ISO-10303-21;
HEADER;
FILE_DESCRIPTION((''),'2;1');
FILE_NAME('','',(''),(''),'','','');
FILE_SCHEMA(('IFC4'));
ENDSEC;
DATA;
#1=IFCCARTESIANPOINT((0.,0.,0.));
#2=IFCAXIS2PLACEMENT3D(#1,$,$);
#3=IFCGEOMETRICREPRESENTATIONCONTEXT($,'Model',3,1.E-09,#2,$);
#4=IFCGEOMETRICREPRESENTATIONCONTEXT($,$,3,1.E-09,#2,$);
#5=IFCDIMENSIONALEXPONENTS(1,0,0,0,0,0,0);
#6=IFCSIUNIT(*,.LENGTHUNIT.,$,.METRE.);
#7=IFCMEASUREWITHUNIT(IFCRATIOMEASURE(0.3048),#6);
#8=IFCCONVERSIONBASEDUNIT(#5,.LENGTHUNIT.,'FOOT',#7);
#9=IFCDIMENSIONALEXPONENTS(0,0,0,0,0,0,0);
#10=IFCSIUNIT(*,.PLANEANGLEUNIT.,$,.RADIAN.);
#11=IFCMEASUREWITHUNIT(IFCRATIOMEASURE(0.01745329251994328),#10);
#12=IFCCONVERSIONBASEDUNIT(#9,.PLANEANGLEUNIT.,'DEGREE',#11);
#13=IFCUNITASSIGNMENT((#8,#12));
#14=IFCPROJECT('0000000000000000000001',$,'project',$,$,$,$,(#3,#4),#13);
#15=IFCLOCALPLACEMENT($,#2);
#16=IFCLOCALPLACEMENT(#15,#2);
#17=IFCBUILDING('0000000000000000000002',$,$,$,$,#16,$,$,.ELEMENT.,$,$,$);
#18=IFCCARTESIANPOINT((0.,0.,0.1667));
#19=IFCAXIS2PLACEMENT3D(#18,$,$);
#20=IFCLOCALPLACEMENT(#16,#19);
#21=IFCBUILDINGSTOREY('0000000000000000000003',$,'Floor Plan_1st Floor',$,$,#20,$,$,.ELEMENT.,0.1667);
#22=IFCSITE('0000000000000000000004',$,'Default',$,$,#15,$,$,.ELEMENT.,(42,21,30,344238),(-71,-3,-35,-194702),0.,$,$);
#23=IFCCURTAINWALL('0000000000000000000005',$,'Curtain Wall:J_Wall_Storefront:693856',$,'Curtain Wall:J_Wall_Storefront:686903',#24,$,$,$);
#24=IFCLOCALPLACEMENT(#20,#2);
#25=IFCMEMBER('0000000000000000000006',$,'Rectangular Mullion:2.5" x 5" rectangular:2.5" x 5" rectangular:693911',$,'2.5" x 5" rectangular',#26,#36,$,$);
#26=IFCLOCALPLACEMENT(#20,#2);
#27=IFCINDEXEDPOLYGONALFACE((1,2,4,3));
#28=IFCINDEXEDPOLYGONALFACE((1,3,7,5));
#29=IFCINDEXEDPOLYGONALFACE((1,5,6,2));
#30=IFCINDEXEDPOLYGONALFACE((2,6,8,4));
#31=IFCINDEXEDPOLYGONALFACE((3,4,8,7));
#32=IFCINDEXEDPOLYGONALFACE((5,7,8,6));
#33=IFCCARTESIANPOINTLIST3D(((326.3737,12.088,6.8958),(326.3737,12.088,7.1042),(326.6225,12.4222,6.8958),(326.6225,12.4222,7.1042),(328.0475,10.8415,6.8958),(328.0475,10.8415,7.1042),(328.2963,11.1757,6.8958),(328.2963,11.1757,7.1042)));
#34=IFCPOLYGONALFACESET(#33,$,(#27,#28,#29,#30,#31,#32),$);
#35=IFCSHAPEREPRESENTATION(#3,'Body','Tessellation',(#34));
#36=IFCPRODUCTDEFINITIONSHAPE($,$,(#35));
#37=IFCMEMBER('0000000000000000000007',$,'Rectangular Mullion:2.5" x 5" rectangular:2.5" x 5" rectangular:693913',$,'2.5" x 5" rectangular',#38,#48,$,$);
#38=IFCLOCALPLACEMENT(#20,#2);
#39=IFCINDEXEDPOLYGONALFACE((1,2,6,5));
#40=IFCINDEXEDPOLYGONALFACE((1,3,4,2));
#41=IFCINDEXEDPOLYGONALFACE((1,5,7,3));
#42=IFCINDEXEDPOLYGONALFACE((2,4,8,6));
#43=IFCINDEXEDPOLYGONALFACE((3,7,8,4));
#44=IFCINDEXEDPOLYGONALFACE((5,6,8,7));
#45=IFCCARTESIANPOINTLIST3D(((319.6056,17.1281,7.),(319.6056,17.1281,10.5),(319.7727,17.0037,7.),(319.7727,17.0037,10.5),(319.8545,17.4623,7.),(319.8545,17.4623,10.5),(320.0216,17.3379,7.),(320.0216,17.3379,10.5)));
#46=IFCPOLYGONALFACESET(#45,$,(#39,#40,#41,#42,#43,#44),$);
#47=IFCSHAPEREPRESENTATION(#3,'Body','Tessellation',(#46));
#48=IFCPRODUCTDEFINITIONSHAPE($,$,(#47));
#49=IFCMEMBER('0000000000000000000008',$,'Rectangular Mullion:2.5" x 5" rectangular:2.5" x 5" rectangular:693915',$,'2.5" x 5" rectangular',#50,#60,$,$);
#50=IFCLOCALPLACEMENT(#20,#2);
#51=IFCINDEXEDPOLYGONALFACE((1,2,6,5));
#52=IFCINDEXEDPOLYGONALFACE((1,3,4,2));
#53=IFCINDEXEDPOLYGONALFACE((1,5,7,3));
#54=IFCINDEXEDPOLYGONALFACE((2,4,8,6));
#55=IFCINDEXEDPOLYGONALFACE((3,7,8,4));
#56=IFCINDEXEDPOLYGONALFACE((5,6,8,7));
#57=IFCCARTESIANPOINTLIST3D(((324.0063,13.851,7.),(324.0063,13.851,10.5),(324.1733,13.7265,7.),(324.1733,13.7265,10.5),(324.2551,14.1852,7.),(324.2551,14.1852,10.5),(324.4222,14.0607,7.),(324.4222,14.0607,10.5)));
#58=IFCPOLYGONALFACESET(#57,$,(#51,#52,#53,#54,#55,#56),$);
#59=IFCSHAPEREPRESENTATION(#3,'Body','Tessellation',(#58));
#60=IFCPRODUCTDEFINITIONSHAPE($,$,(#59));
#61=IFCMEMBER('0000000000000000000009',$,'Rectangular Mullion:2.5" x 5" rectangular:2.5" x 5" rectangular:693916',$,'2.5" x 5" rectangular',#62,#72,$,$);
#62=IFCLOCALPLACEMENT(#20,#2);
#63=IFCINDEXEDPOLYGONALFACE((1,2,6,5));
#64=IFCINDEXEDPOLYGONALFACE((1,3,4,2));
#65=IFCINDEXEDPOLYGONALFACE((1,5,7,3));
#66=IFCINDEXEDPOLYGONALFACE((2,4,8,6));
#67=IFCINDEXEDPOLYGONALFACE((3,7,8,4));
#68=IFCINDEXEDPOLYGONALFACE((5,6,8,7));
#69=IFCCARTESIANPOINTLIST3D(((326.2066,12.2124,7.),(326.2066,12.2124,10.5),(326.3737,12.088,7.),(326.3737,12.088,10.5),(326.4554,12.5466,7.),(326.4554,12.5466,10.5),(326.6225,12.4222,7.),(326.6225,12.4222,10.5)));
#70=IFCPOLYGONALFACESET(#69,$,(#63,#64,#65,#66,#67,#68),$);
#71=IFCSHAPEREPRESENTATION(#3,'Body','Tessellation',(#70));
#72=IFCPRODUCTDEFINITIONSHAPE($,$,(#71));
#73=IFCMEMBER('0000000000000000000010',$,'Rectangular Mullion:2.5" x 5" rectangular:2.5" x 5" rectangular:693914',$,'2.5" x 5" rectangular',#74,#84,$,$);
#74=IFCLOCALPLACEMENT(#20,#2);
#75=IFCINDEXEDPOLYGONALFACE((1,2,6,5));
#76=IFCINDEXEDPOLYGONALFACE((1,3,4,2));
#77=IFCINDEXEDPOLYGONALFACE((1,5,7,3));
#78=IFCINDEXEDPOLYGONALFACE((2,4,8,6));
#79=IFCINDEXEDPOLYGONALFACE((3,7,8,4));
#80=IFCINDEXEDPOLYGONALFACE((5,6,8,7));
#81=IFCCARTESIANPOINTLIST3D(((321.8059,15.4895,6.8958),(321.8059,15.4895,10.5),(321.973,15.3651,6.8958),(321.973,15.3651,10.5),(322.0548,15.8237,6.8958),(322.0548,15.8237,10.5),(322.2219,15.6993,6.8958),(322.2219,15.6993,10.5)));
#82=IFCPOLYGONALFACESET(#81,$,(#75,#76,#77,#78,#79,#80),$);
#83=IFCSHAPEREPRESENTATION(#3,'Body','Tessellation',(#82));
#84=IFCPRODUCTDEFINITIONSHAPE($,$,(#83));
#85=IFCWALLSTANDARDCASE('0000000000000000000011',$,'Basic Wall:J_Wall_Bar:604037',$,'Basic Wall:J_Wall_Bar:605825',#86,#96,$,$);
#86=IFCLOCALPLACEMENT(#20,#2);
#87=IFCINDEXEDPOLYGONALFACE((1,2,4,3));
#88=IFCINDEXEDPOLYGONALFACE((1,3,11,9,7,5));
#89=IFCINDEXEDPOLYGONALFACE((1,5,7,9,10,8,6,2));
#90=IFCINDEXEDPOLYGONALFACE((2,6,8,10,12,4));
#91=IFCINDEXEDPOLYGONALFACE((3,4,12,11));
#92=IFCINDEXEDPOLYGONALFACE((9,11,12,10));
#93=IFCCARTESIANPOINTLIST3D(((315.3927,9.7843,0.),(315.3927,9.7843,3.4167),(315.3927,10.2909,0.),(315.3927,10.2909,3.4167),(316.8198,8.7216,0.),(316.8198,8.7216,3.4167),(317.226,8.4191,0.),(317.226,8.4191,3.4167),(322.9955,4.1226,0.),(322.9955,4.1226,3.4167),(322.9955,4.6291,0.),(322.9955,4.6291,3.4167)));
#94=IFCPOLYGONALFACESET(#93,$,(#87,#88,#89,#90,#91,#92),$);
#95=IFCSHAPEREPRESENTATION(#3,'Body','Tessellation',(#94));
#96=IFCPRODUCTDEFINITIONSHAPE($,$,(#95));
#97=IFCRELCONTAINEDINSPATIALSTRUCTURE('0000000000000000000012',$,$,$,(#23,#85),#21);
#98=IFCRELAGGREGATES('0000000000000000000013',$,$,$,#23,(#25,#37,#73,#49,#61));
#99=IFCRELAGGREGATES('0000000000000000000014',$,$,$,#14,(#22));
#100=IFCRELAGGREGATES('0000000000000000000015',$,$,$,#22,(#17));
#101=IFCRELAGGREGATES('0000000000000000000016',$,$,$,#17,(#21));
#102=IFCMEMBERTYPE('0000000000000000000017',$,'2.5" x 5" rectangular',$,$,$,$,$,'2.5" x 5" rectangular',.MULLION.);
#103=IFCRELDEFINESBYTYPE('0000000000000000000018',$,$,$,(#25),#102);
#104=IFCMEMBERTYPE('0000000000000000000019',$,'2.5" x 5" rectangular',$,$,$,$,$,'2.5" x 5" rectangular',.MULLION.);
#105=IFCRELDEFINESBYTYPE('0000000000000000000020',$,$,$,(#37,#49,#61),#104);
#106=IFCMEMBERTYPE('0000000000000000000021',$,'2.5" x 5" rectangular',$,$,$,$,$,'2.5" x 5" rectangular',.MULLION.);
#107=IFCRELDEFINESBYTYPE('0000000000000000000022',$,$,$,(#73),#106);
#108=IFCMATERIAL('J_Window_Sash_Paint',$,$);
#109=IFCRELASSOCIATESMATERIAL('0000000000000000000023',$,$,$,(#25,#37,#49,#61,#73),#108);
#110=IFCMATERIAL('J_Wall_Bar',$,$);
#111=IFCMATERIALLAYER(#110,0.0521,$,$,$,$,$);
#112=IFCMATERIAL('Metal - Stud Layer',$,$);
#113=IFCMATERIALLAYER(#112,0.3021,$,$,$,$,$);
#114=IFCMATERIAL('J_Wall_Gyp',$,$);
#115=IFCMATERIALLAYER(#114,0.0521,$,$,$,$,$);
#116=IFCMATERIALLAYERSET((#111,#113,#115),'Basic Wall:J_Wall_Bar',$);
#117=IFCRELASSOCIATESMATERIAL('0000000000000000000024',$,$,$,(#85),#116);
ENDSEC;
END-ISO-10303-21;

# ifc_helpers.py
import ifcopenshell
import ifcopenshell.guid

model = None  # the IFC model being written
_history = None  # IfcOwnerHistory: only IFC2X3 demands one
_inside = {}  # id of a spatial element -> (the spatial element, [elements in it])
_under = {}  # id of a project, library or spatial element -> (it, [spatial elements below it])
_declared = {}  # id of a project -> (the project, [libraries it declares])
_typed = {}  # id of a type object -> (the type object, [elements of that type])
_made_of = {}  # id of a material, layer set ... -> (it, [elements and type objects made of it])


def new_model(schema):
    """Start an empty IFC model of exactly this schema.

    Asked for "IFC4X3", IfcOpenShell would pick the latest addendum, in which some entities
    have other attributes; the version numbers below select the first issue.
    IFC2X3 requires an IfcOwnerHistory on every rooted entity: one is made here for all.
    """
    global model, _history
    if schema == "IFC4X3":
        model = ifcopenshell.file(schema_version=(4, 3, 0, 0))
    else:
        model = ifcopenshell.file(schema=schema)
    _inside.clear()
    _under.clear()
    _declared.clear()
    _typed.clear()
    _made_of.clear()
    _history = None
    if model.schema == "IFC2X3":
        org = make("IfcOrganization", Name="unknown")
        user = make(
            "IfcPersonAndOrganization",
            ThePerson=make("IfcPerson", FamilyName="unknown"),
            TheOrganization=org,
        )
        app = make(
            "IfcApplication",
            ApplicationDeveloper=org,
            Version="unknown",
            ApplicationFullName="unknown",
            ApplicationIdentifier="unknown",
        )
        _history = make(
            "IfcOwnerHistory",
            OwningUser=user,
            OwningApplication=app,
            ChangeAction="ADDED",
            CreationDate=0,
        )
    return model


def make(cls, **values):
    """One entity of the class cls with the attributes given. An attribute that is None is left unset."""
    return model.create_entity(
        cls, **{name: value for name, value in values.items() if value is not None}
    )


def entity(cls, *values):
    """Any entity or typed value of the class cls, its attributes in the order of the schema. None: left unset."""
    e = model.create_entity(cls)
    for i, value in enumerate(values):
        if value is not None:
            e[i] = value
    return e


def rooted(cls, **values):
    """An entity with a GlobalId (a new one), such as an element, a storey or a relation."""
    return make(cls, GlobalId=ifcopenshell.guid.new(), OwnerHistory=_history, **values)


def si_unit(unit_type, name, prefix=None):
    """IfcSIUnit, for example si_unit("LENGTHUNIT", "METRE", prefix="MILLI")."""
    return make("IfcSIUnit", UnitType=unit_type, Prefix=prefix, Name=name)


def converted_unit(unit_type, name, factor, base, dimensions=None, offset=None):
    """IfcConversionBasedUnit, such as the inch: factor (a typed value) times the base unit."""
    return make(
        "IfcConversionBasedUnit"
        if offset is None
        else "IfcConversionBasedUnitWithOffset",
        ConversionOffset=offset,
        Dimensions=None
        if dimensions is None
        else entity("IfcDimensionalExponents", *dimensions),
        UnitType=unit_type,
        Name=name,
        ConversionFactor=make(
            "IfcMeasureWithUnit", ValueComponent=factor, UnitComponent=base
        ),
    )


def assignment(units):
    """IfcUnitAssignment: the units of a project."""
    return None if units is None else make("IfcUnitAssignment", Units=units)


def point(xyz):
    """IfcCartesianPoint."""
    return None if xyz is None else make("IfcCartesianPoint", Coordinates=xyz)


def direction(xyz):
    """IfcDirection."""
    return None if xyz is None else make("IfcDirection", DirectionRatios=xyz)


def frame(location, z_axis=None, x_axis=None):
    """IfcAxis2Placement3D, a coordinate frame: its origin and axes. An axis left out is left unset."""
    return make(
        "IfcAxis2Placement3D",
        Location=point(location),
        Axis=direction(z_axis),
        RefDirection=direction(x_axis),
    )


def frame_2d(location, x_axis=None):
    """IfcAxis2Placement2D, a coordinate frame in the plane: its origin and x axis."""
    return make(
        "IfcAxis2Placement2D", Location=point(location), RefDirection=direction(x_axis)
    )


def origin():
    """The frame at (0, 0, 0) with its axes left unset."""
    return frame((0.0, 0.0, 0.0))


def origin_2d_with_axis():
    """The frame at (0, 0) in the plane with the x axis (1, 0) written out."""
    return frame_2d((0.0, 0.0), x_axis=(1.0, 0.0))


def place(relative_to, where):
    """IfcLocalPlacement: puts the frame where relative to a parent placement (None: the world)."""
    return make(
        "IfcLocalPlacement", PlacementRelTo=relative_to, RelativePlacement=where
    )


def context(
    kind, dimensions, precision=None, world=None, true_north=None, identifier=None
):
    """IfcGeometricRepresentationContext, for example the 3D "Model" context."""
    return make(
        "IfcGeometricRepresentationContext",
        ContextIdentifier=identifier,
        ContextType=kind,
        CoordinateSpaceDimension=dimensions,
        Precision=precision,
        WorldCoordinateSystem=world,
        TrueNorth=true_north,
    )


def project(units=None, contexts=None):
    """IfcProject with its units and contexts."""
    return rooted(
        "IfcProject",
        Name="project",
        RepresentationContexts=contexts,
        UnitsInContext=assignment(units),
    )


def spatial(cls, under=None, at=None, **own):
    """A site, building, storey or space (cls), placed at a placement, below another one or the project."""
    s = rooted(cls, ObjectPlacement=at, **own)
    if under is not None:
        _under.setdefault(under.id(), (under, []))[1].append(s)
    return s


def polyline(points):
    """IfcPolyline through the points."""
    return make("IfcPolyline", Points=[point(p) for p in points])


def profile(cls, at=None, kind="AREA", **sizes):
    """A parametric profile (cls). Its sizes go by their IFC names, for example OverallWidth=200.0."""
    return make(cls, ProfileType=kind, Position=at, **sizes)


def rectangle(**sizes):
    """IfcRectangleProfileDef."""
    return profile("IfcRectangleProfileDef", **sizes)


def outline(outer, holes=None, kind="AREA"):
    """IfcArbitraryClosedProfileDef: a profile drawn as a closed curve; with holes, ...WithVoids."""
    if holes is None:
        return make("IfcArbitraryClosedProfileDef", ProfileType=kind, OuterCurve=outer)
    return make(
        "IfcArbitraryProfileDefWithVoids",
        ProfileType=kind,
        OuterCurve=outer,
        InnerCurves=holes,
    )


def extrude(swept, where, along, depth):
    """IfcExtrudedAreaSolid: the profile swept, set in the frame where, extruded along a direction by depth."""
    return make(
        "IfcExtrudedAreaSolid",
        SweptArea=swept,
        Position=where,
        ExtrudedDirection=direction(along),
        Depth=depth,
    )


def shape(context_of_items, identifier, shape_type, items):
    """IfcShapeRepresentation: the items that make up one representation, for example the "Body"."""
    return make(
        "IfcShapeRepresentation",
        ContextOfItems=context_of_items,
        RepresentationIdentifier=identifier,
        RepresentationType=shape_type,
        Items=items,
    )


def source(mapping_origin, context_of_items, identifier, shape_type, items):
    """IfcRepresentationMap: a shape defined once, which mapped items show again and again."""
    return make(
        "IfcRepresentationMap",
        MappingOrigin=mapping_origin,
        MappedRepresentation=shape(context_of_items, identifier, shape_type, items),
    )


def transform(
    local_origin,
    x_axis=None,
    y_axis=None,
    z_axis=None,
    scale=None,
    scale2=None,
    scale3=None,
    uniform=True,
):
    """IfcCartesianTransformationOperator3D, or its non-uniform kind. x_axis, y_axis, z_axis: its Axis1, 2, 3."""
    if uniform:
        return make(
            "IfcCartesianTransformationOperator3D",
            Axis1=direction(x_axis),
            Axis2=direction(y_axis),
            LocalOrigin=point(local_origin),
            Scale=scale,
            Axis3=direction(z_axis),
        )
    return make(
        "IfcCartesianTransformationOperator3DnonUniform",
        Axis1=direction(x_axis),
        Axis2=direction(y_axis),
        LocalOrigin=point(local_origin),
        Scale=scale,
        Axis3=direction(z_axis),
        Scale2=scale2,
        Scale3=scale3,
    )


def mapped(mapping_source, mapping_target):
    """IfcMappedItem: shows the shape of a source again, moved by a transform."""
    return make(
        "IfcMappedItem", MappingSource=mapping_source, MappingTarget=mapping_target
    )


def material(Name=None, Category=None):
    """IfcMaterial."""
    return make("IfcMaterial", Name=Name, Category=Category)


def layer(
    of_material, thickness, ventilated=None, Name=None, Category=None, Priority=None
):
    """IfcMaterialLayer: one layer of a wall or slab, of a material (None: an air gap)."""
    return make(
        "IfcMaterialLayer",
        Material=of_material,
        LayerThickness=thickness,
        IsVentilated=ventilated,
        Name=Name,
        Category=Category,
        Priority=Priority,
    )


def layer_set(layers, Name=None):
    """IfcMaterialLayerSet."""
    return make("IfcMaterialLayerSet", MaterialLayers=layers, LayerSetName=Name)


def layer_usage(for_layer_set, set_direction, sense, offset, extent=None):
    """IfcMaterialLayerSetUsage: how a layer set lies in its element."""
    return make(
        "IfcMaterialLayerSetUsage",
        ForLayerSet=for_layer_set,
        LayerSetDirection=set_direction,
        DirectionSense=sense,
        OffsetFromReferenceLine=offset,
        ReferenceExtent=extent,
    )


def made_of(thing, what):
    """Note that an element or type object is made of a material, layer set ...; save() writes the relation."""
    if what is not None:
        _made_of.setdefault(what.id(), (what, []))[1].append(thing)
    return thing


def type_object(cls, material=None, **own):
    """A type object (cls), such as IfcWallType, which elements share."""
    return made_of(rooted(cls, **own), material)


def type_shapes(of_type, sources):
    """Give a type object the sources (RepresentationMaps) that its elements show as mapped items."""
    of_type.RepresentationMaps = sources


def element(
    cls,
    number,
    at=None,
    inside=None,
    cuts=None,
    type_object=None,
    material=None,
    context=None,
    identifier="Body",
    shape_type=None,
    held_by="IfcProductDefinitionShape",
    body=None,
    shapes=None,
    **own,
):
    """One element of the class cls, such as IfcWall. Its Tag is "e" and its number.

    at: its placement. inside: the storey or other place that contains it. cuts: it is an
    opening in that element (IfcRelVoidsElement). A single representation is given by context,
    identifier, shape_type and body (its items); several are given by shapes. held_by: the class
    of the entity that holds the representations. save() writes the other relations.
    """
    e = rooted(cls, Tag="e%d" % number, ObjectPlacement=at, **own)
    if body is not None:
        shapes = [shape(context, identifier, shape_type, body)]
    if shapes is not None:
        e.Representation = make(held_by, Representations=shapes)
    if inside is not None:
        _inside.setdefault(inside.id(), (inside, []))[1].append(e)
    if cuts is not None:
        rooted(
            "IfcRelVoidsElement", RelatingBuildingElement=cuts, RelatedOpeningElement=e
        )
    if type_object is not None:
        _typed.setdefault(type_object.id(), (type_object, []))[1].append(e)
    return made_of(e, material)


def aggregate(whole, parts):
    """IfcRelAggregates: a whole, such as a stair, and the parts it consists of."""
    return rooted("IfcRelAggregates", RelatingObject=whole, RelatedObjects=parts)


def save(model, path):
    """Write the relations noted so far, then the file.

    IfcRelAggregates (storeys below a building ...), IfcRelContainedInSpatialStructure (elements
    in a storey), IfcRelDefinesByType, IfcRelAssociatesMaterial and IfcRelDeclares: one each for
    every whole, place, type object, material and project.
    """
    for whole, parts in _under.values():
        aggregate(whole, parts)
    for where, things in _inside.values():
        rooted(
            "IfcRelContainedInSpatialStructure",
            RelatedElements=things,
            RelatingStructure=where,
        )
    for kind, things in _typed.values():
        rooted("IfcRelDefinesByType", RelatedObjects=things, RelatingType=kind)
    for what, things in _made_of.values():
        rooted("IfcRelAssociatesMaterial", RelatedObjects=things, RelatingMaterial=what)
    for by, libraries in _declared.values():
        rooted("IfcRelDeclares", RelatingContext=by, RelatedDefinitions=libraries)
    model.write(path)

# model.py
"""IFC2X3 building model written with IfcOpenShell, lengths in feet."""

from ifc_helpers import new_model, entity, si_unit, converted_unit, frame, origin, origin_2d_with_axis, place, context, project, spatial, polyline, rectangle, outline, extrude, source, transform, mapped, material, layer, layer_set, layer_usage, type_object, type_shapes, element, aggregate, save


model = new_model("IFC2X3")

# Units and contexts
model_context = context("Model", 3, precision=1e-09, world=origin())
context_of_model = context(None, 3, precision=1e-09, world=origin())
ifc_project = project(units=[converted_unit("LENGTHUNIT", "FOOT", entity("IfcRatioMeasure", 0.3048), si_unit("LENGTHUNIT", "METRE"), dimensions=[1, 0, 0, 0, 0, 0, 0]), converted_unit("PLANEANGLEUNIT", "DEGREE", entity("IfcRatioMeasure", 0.01745329251994328), si_unit("PLANEANGLEUNIT", "RADIAN"), dimensions=[0, 0, 0, 0, 0, 0, 0])], contexts=[model_context, context_of_model])

# Site, building, storey
site_placement = place(None, origin())
site = spatial("IfcSite", under=ifc_project, at=site_placement, Name="Default", CompositionType="ELEMENT", RefLatitude=(42, 21, 30, 344238), RefLongitude=(-71, -3, -35, -194702), RefElevation=0.0)
building_placement = place(site_placement, origin())
building = spatial("IfcBuilding", under=site, at=building_placement, CompositionType="ELEMENT")
storey_placement = place(building_placement, frame((0.0, 0.0, 0.1667)))
storey = spatial("IfcBuildingStorey", under=building, at=storey_placement, Name="Floor Plan_1st Floor", CompositionType="ELEMENT", Elevation=0.1667)

# Curtain wall, members
curtain_wall_placement = place(storey_placement, origin())
curtain_wall = element("IfcCurtainWall", 1, at=curtain_wall_placement, inside=storey, Name="Curtain Wall:J_Wall_Storefront:693856", ObjectType="Curtain Wall:J_Wall_Storefront:686903")
ifc_material_1 = material(Name="J_Window_Sash_Paint")
member_type_1 = type_object("IfcMemberType", Name="2.5\" x 5\" rectangular", ElementType="2.5\" x 5\" rectangular", PredefinedType="MULLION")
shared_shape_1 = source(origin(), model_context, "Body", "SweptSolid", [
    extrude(rectangle(XDim=0.2083, YDim=0.4167, at=origin_2d_with_axis()), frame((0.0, 0.0, -2.0869), z_axis=(0.0, 0.0, 1.0), x_axis=(-1.0, 0.0, 0.0)), (0.0, 0.0, 1.0), 2.0869),
])
type_shapes(member_type_1, [shared_shape_1])
member_1_placement = place(storey_placement, frame((328.1719, 11.0086, 7.0), z_axis=(0.802039, -0.597272, 0.0), x_axis=(0.0, 0.0, 1.0)))
member_1 = element("IfcMember", 2, at=member_1_placement, type_object=member_type_1, material=ifc_material_1, Name="Rectangular Mullion:2.5\" x 5\" rectangular:2.5\" x 5\" rectangular:693911", ObjectType="2.5\" x 5\" rectangular", context=model_context, shape_type="MappedRepresentation", body=[
    mapped(shared_shape_1, transform((0.0, 0.0, 0.0), scale=1.0)),
])
member_type_2 = type_object("IfcMemberType", Name="2.5\" x 5\" rectangular", ElementType="2.5\" x 5\" rectangular", PredefinedType="MULLION")
shared_shape_2 = source(origin(), model_context, "Body", "SweptSolid", [
    extrude(rectangle(XDim=0.2083, YDim=0.4167, at=origin_2d_with_axis()), frame((0.0, 0.0, -3.5), z_axis=(0.0, 0.0, 1.0), x_axis=(-1.0, 0.0, 0.0)), (0.0, 0.0, 1.0), 3.5),
])
type_shapes(member_type_2, [shared_shape_2])
member_2_placement = place(storey_placement, frame((319.8136, 17.233, 7.0), z_axis=(0.0, 0.0, -1.0), x_axis=(0.802039, -0.597272, 0.0)))
member_2 = element("IfcMember", 3, at=member_2_placement, type_object=member_type_2, material=ifc_material_1, Name="Rectangular Mullion:2.5\" x 5\" rectangular:2.5\" x 5\" rectangular:693913", ObjectType="2.5\" x 5\" rectangular", context=model_context, shape_type="MappedRepresentation", body=[
    mapped(shared_shape_2, transform((0.0, 0.0, 0.0), scale=1.0)),
])
member_3_placement = place(storey_placement, frame((324.2142, 13.9559, 7.0), z_axis=(0.0, 0.0, -1.0), x_axis=(0.802039, -0.597272, 0.0)))
member_3 = element("IfcMember", 4, at=member_3_placement, type_object=member_type_2, material=ifc_material_1, Name="Rectangular Mullion:2.5\" x 5\" rectangular:2.5\" x 5\" rectangular:693915", ObjectType="2.5\" x 5\" rectangular", context=model_context, shape_type="MappedRepresentation", body=[
    mapped(shared_shape_2, transform((0.0, 0.0, 0.0), scale=1.0)),
])
member_4_placement = place(storey_placement, frame((326.4146, 12.3173, 7.0), z_axis=(0.0, 0.0, -1.0), x_axis=(0.802039, -0.597272, 0.0)))
member_4 = element("IfcMember", 5, at=member_4_placement, type_object=member_type_2, material=ifc_material_1, Name="Rectangular Mullion:2.5\" x 5\" rectangular:2.5\" x 5\" rectangular:693916", ObjectType="2.5\" x 5\" rectangular", context=model_context, shape_type="MappedRepresentation", body=[
    mapped(shared_shape_2, transform((0.0, 0.0, 0.0), scale=1.0)),
])
member_type_3 = type_object("IfcMemberType", Name="2.5\" x 5\" rectangular", ElementType="2.5\" x 5\" rectangular", PredefinedType="MULLION")
shared_shape_3 = source(origin(), model_context, "Body", "SweptSolid", [
    extrude(rectangle(XDim=0.2083, YDim=0.4167, at=origin_2d_with_axis()), frame((0.0, 0.0, -3.6042), z_axis=(0.0, 0.0, 1.0), x_axis=(-1.0, 0.0, 0.0)), (0.0, 0.0, 1.0), 3.6042),
])
type_shapes(member_type_3, [shared_shape_3])
member_5_placement = place(storey_placement, frame((322.0139, 15.5944, 6.8958), z_axis=(0.0, 0.0, -1.0), x_axis=(0.802039, -0.597272, 0.0)))
member_5 = element("IfcMember", 6, at=member_5_placement, type_object=member_type_3, material=ifc_material_1, Name="Rectangular Mullion:2.5\" x 5\" rectangular:2.5\" x 5\" rectangular:693914", ObjectType="2.5\" x 5\" rectangular", context=model_context, shape_type="MappedRepresentation", body=[
    mapped(shared_shape_3, transform((0.0, 0.0, 0.0), scale=1.0)),
])
aggregate(curtain_wall, [member_1, member_2, member_5, member_3, member_4])

# Wall
ifc_material_2 = material(Name="J_Wall_Bar")
ifc_layer_1 = layer(ifc_material_2, 0.0521)
ifc_material_3 = material(Name="Metal - Stud Layer")
ifc_layer_2 = layer(ifc_material_3, 0.3021)
ifc_material_4 = material(Name="J_Wall_Gyp")
ifc_layer_3 = layer(ifc_material_4, 0.0521)
ifc_layer_set = layer_set([ifc_layer_1, ifc_layer_2, ifc_layer_3], Name="Basic Wall:J_Wall_Bar")
ifc_layer_usage = layer_usage(ifc_layer_set, "AXIS2", "POSITIVE", -0.2031)
wall_placement = place(storey_placement, frame((323.1168, 4.2855, 0.0), z_axis=(0.0, 0.0, 1.0), x_axis=(-0.802039, 0.597272, 0.0)))
element("IfcWallStandardCase", 7, at=wall_placement, inside=storey, material=ifc_layer_usage, Name="Basic Wall:J_Wall_Bar:604037", ObjectType="Basic Wall:J_Wall_Bar:605825", context=model_context, shape_type="SweptSolid", body=[
    extrude(outline(polyline([(9.7819, -0.2031), (9.4793, 0.2031), (7.7, 0.2031), (7.1935, 0.2031), (0.0, 0.2031), (0.3025, -0.2031), (9.7819, -0.2031)])), origin(), (0.0, 0.0, 1.0), 3.4167),
])

save(model, "model.ifc")
